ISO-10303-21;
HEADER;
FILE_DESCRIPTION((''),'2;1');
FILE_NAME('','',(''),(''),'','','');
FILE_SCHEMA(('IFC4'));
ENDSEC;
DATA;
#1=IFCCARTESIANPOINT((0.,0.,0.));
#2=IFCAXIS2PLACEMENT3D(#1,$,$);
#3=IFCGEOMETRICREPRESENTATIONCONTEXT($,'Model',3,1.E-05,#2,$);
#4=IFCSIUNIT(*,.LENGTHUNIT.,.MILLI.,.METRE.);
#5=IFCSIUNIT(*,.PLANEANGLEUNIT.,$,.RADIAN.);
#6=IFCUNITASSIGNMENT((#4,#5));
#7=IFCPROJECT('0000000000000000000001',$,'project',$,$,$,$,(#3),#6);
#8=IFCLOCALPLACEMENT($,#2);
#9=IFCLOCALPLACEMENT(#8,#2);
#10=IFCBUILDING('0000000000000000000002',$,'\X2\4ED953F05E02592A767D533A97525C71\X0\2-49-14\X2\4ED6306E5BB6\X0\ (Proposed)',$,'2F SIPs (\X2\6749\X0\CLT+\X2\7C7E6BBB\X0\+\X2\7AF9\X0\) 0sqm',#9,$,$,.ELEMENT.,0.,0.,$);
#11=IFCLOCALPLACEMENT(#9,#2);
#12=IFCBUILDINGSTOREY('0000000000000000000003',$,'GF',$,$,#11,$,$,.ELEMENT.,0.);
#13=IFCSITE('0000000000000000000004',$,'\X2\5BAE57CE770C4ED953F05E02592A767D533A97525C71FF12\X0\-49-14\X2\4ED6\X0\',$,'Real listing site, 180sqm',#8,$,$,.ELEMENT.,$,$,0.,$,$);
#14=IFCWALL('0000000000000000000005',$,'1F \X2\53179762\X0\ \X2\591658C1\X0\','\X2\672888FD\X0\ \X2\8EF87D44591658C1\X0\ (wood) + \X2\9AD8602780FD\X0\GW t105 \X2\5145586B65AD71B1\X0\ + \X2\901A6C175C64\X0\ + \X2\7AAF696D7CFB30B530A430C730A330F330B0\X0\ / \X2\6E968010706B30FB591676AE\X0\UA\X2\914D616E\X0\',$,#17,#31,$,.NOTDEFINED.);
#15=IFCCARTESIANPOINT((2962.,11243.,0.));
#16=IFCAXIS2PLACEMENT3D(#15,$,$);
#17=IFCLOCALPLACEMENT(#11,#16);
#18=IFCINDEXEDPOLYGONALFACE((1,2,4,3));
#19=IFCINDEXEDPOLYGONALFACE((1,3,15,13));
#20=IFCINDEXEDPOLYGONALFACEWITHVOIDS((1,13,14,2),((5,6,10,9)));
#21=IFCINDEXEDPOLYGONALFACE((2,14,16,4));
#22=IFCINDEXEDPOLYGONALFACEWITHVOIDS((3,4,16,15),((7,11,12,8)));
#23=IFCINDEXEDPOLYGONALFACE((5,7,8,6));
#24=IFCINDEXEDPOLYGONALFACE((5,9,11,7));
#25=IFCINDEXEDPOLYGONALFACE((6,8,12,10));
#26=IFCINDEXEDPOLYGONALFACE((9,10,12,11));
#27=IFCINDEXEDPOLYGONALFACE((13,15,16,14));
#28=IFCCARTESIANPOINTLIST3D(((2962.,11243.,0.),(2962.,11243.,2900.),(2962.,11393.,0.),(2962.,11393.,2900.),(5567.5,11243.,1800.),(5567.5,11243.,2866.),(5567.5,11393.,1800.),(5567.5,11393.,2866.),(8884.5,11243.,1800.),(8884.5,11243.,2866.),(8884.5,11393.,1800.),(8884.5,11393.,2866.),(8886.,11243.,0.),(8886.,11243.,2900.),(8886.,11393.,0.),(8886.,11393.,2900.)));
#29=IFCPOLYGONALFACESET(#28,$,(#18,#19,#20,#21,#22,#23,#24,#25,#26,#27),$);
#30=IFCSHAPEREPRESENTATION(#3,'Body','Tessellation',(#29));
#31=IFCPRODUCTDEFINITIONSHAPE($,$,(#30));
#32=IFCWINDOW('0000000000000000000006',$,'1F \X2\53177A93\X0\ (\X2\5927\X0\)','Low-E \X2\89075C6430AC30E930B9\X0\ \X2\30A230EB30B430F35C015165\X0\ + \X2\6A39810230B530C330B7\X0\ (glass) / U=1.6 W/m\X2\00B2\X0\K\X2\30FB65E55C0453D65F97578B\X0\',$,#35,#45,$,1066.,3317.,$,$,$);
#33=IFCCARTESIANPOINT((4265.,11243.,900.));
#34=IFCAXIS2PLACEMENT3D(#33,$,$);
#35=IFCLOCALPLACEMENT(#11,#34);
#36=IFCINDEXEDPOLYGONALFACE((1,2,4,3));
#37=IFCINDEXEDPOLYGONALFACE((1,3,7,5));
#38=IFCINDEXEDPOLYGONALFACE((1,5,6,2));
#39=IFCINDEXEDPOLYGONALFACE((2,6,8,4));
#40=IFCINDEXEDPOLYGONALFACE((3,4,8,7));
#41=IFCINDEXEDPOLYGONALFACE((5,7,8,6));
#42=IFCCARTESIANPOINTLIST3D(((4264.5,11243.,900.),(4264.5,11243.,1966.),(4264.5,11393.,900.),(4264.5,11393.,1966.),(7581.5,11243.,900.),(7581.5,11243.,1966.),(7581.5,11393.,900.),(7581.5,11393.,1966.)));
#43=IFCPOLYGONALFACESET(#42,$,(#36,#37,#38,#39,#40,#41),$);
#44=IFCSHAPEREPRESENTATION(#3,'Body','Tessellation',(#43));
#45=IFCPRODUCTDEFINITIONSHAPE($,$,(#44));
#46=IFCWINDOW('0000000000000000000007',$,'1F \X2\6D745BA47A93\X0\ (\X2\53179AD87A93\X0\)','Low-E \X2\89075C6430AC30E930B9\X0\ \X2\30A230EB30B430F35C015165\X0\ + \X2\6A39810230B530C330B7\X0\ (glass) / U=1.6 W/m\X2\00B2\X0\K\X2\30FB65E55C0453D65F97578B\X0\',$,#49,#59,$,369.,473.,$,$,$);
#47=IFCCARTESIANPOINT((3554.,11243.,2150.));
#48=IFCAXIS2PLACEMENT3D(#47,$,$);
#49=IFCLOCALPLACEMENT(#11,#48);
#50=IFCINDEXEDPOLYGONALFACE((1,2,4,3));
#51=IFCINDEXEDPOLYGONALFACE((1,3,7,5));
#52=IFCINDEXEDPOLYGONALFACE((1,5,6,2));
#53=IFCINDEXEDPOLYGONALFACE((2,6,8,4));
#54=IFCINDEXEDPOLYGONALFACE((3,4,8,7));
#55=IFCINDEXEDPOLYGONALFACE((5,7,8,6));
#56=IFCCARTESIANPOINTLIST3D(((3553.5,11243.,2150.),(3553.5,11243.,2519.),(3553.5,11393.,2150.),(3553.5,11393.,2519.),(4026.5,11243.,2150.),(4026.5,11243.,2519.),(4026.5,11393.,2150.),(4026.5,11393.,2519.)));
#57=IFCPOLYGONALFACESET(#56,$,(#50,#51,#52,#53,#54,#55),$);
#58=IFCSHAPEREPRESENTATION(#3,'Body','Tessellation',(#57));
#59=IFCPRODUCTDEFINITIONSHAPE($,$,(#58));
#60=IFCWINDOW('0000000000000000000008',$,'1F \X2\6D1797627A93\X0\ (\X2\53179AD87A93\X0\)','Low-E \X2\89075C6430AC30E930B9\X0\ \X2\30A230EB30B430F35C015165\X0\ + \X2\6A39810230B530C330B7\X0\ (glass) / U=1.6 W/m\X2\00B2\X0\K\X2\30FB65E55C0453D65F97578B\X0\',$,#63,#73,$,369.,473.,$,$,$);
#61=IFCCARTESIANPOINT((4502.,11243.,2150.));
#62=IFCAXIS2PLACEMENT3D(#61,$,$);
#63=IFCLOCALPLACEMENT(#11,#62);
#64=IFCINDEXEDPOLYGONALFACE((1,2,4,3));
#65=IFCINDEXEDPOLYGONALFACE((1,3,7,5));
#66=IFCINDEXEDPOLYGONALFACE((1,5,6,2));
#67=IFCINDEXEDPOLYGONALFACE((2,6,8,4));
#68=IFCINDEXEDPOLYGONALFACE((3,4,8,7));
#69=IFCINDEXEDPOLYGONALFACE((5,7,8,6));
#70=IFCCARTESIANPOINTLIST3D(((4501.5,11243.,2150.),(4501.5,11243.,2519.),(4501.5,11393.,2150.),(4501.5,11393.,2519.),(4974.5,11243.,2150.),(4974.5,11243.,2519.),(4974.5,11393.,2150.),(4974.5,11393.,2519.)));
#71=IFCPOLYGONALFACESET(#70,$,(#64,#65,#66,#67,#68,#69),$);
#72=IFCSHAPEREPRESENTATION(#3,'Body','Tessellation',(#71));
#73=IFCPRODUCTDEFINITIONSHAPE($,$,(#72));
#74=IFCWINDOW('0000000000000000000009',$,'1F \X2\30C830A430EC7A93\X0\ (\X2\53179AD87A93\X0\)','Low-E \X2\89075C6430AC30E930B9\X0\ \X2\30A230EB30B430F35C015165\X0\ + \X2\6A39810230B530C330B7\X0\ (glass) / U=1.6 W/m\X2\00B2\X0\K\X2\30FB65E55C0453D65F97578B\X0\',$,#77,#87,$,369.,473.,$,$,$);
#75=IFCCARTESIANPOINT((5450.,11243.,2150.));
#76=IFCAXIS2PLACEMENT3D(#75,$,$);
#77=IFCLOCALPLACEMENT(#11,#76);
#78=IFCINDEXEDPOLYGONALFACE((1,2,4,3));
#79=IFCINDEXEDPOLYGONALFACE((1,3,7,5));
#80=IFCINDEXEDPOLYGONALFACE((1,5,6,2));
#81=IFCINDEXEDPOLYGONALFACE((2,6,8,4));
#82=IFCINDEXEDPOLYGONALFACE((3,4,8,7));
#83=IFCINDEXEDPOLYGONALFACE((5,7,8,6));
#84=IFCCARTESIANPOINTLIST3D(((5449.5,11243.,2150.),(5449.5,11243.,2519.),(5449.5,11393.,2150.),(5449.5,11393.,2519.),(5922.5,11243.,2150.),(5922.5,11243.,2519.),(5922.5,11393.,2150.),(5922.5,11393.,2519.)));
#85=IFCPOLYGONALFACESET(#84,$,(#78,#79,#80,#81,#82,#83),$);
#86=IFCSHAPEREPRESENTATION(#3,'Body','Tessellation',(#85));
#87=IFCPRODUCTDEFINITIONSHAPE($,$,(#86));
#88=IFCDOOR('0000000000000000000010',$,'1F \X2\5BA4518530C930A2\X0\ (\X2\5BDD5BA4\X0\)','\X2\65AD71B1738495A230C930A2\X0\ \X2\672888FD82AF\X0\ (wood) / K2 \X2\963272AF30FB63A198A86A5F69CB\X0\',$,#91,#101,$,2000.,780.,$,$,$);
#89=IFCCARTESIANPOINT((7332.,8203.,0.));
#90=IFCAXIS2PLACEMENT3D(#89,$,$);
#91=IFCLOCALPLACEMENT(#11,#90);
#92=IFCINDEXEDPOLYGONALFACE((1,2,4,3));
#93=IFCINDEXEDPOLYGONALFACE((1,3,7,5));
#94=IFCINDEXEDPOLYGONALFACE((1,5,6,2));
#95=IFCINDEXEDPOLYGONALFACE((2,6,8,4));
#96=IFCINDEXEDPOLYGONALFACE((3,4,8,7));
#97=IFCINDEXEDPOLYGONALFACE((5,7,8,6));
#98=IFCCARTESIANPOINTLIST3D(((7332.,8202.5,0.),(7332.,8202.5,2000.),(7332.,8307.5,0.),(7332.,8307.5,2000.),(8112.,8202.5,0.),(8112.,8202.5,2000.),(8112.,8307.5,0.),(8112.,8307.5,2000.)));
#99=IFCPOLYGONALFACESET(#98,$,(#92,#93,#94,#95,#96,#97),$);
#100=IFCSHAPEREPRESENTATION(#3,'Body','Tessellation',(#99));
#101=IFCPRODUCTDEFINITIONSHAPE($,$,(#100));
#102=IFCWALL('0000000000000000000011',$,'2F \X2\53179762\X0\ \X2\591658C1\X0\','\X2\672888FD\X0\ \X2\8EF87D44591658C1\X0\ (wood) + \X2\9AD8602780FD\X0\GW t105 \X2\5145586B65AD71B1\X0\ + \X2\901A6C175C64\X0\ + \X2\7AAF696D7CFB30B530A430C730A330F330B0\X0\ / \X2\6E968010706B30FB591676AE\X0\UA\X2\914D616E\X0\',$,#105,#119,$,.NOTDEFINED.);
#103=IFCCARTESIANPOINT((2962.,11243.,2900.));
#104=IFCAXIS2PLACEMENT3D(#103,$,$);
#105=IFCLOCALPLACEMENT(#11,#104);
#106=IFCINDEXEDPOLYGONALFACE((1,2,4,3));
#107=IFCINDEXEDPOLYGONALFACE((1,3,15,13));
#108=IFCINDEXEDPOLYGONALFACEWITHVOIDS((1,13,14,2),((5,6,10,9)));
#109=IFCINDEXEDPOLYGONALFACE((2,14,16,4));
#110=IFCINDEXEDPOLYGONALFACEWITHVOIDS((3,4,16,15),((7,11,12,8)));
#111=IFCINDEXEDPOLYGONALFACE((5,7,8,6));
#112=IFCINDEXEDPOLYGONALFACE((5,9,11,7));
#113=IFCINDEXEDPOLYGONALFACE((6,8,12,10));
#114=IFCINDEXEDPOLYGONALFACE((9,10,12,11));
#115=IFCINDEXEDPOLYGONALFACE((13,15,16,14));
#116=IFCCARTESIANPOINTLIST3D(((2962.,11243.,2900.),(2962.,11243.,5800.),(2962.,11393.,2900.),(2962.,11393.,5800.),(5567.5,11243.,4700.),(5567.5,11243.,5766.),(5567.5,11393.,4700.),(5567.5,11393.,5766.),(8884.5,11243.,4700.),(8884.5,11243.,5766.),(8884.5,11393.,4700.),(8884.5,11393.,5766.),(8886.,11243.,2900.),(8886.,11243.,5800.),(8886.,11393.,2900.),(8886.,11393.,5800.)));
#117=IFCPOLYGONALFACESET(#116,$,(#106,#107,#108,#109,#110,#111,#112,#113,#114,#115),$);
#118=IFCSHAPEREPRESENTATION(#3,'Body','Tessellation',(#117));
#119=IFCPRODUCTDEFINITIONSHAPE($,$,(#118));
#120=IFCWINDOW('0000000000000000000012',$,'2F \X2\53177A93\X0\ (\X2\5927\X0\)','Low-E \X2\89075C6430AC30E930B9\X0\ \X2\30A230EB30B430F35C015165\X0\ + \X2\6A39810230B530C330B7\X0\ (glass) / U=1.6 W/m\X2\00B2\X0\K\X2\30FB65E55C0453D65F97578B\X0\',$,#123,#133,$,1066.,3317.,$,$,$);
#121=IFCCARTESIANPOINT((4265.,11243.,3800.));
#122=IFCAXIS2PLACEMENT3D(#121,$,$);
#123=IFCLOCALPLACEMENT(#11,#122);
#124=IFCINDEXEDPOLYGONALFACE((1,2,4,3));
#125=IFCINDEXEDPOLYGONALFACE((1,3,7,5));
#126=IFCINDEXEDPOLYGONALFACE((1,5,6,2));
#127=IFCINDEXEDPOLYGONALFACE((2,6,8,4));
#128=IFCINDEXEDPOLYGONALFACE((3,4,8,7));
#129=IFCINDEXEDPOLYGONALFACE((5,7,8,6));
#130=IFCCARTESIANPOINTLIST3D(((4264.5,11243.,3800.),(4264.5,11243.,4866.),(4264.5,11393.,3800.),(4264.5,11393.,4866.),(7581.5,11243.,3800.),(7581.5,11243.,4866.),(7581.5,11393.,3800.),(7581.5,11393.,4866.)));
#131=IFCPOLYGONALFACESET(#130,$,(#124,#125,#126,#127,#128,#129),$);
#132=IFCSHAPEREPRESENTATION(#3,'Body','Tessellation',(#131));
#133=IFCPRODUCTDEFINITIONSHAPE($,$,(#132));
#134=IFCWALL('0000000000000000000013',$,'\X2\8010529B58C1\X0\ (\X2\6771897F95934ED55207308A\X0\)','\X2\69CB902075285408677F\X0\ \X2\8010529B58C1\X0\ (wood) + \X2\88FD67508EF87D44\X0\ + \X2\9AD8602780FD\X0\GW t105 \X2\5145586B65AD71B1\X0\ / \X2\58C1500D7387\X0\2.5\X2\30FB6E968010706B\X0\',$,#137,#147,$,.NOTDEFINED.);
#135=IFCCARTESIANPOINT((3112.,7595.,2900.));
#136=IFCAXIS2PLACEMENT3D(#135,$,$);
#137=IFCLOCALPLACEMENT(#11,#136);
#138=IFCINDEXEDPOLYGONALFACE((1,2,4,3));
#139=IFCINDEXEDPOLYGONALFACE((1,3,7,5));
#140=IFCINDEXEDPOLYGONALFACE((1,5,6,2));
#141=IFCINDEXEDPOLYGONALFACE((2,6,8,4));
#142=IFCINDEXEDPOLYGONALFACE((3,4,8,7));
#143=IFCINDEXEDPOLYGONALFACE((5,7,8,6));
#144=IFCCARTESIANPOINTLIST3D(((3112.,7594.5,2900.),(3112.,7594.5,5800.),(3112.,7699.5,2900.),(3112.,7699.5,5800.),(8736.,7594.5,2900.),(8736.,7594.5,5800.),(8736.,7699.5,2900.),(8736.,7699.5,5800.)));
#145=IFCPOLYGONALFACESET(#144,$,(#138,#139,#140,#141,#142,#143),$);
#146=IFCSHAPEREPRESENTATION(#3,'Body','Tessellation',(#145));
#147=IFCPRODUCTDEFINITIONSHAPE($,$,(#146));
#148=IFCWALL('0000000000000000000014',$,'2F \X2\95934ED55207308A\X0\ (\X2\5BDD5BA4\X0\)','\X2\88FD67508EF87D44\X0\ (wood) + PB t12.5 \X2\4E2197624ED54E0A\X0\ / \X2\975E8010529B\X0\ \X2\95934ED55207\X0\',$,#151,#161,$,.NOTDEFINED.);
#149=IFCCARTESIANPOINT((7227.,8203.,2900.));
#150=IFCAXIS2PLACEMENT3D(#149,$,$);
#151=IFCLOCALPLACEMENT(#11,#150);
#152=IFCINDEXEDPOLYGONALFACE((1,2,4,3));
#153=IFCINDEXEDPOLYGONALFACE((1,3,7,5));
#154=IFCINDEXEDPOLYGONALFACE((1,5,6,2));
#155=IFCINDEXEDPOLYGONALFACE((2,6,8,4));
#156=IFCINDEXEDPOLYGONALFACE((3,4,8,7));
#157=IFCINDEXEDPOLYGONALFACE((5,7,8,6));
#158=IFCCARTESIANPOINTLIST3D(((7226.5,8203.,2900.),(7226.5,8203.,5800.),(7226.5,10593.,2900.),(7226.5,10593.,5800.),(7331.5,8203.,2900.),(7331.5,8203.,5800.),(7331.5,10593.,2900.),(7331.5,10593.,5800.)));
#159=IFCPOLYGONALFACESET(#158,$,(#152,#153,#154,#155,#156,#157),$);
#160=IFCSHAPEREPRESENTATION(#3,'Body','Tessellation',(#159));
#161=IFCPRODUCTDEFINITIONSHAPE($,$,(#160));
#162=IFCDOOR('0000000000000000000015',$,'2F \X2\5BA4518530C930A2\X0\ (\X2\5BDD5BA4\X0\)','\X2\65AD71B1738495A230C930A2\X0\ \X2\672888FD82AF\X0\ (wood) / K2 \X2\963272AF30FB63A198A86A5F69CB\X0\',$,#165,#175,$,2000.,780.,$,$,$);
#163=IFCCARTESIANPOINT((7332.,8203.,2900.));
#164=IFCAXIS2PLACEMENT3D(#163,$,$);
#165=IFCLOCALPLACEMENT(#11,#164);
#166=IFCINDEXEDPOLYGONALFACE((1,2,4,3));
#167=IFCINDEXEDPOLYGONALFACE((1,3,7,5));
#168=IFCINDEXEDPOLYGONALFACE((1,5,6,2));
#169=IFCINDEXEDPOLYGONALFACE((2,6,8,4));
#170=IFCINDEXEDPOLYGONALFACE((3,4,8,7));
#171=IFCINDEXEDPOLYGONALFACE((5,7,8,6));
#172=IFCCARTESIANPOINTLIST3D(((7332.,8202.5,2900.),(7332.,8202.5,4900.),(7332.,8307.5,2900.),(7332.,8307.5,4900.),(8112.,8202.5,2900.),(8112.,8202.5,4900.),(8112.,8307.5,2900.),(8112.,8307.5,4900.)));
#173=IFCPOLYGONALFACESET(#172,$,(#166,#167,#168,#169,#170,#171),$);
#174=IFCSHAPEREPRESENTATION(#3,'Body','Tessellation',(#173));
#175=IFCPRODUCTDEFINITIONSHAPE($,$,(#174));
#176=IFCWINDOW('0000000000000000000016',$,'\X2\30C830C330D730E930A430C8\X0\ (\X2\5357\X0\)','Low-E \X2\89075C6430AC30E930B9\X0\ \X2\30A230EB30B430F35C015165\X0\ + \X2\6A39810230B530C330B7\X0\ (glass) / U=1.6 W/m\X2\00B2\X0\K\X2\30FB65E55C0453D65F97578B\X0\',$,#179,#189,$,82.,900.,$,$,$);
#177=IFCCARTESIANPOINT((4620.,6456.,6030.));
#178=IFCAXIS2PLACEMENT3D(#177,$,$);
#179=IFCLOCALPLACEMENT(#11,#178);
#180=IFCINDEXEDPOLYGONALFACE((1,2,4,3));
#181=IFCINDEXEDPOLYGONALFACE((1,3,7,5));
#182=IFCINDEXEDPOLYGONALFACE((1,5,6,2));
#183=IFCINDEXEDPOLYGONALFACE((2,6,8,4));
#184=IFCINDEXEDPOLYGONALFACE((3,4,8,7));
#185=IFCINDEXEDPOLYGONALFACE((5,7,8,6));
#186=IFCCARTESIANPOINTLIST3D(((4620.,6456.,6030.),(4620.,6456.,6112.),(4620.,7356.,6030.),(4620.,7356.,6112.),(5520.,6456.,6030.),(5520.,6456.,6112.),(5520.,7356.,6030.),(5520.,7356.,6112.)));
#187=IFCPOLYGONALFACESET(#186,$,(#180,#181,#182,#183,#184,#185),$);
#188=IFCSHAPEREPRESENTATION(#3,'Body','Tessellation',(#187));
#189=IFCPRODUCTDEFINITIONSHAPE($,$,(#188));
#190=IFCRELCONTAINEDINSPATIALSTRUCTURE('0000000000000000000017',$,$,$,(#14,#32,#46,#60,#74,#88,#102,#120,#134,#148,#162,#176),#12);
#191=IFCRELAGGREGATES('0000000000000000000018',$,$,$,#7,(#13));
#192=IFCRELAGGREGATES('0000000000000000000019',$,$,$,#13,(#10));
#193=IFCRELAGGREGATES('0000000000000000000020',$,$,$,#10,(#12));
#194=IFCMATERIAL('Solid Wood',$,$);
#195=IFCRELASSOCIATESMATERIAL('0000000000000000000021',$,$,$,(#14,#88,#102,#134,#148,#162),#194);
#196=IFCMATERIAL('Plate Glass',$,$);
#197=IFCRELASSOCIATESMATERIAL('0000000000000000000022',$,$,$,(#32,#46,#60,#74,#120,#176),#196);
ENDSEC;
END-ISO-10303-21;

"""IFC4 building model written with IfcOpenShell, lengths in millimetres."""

from ifc_helpers import new_model, si_unit, frame, frame_2d, origin, place, context, project, spatial, rectangle, extrude, material, element, fill, save


model = new_model("IFC4")

# Units and contexts
model_context = context("Model", 3, precision=1e-05, world=origin())
ifc_project = project(units=[si_unit("LENGTHUNIT", "METRE", prefix="MILLI"), si_unit("PLANEANGLEUNIT", "RADIAN")], contexts=[model_context])

# Site, building, storey
site_placement = place(None, origin())
site = spatial("IfcSite", under=ifc_project, at=site_placement, Name="宮城県仙台市太白区青山２-49-14他", ObjectType="Real listing site, 180sqm", CompositionType="ELEMENT", RefElevation=0.0)
building_placement = place(site_placement, origin())
building = spatial("IfcBuilding", under=site, at=building_placement, Name="仙台市太白区青山2-49-14他の家 (Proposed)", ObjectType="2F SIPs (杉CLT+籾殻+竹) 0sqm", CompositionType="ELEMENT", ElevationOfRefHeight=0.0, ElevationOfTerrain=0.0)
storey_placement = place(building_placement, origin())
storey = spatial("IfcBuildingStorey", under=building, at=storey_placement, Name="GF", CompositionType="ELEMENT", Elevation=0.0)

# Wall, openings, windows
ifc_material_1 = material(Name="Solid Wood")
wall_1_placement = place(storey_placement, frame((2962.0, 11243.0, 0.0)))
wall_1 = element("IfcWall", 1, at=wall_1_placement, inside=storey, material=ifc_material_1, Name="1F 北面 外壁", Description="木製 軸組外壁 (wood) + 高性能GW t105 充填断熱 + 通気層 + 窯業系サイディング / 準耐火・外皮UA配慮", PredefinedType="NOTDEFINED", context=model_context, shape_type="SweptSolid", body=[
    extrude(rectangle(XDim=5924.0, YDim=150.0, at=frame_2d((2962.0, 75.0))), frame((2962.0, 11243.0, 0.0)), (0.0, 0.0, 1.0), 2900.0),
])
opening_1_placement = place(storey_placement, frame((4265.0, 11243.0, 900.0)))
opening_1 = element("IfcOpeningElement", 2, at=opening_1_placement, cuts=wall_1, PredefinedType="NOTDEFINED", context=model_context, shape_type="SweptSolid", body=[
    extrude(rectangle(XDim=3317.0, YDim=150.0, at=frame_2d((1658.0, 75.0))), frame((4265.0, 11243.0, 900.0)), (0.0, 0.0, 1.0), 1066.0),
])
opening_2_placement = place(storey_placement, frame((3554.0, 11243.0, 2150.0)))
opening_2 = element("IfcOpeningElement", 3, at=opening_2_placement, cuts=wall_1, PredefinedType="NOTDEFINED", context=model_context, shape_type="SweptSolid", body=[
    extrude(rectangle(XDim=473.0, YDim=150.0, at=frame_2d((236.0, 75.0))), frame((3554.0, 11243.0, 2150.0)), (0.0, 0.0, 1.0), 369.0),
])
opening_3_placement = place(storey_placement, frame((4502.0, 11243.0, 2150.0)))
opening_3 = element("IfcOpeningElement", 4, at=opening_3_placement, cuts=wall_1, PredefinedType="NOTDEFINED", context=model_context, shape_type="SweptSolid", body=[
    extrude(rectangle(XDim=473.0, YDim=150.0, at=frame_2d((236.0, 75.0))), frame((4502.0, 11243.0, 2150.0)), (0.0, 0.0, 1.0), 369.0),
])
opening_4_placement = place(storey_placement, frame((5450.0, 11243.0, 2150.0)))
opening_4 = element("IfcOpeningElement", 5, at=opening_4_placement, cuts=wall_1, PredefinedType="NOTDEFINED", context=model_context, shape_type="SweptSolid", body=[
    extrude(rectangle(XDim=473.0, YDim=150.0, at=frame_2d((236.0, 75.0))), frame((5450.0, 11243.0, 2150.0)), (0.0, 0.0, 1.0), 369.0),
])
ifc_material_2 = material(Name="Plate Glass")
window_1_placement = place(storey_placement, frame((4265.0, 11243.0, 900.0)))
window_1 = element("IfcWindow", 6, at=window_1_placement, inside=storey, material=ifc_material_2, Name="1F 北窓 (大)", Description="Low-E 複層ガラス アルゴン封入 + 樹脂サッシ (glass) / U=1.6 W/m²K・日射取得型", OverallHeight=1066.0, OverallWidth=3317.0, context=model_context, shape_type="SweptSolid", body=[
    extrude(rectangle(XDim=3317.0, YDim=150.0, at=frame_2d((1658.0, 75.0))), frame((4265.0, 11243.0, 900.0)), (0.0, 0.0, 1.0), 1066.0),
])
fill(opening_1, window_1)
window_2_placement = place(storey_placement, frame((3554.0, 11243.0, 2150.0)))
window_2 = element("IfcWindow", 7, at=window_2_placement, inside=storey, material=ifc_material_2, Name="1F 浴室窓 (北高窓)", Description="Low-E 複層ガラス アルゴン封入 + 樹脂サッシ (glass) / U=1.6 W/m²K・日射取得型", OverallHeight=369.0, OverallWidth=473.0, context=model_context, shape_type="SweptSolid", body=[
    extrude(rectangle(XDim=473.0, YDim=150.0, at=frame_2d((236.0, 75.0))), frame((3554.0, 11243.0, 2150.0)), (0.0, 0.0, 1.0), 369.0),
])
fill(opening_2, window_2)
window_3_placement = place(storey_placement, frame((4502.0, 11243.0, 2150.0)))
window_3 = element("IfcWindow", 8, at=window_3_placement, inside=storey, material=ifc_material_2, Name="1F 洗面窓 (北高窓)", Description="Low-E 複層ガラス アルゴン封入 + 樹脂サッシ (glass) / U=1.6 W/m²K・日射取得型", OverallHeight=369.0, OverallWidth=473.0, context=model_context, shape_type="SweptSolid", body=[
    extrude(rectangle(XDim=473.0, YDim=150.0, at=frame_2d((236.0, 75.0))), frame((4502.0, 11243.0, 2150.0)), (0.0, 0.0, 1.0), 369.0),
])
fill(opening_3, window_3)
window_4_placement = place(storey_placement, frame((5450.0, 11243.0, 2150.0)))
window_4 = element("IfcWindow", 9, at=window_4_placement, inside=storey, material=ifc_material_2, Name="1F トイレ窓 (北高窓)", Description="Low-E 複層ガラス アルゴン封入 + 樹脂サッシ (glass) / U=1.6 W/m²K・日射取得型", OverallHeight=369.0, OverallWidth=473.0, context=model_context, shape_type="SweptSolid", body=[
    extrude(rectangle(XDim=473.0, YDim=150.0, at=frame_2d((236.0, 75.0))), frame((5450.0, 11243.0, 2150.0)), (0.0, 0.0, 1.0), 369.0),
])
fill(opening_4, window_4)

# Door
door_1_placement = place(storey_placement, frame((7332.0, 8203.0, 0.0)))
element("IfcDoor", 10, at=door_1_placement, inside=storey, material=ifc_material_1, Name="1F 室内ドア (寝室)", Description="断熱玄関ドア 木製芯 (wood) / K2 防犯・採風機構", OverallHeight=2000.0, OverallWidth=780.0, context=model_context, shape_type="SweptSolid", body=[
    extrude(rectangle(XDim=780.0, YDim=105.0, at=frame_2d((390.0, 52.0))), frame((7332.0, 8203.0, 0.0)), (0.0, 0.0, 1.0), 2000.0),
])

# Wall, opening, window
wall_2_placement = place(storey_placement, frame((2962.0, 11243.0, 2900.0)))
wall_2 = element("IfcWall", 11, at=wall_2_placement, inside=storey, material=ifc_material_1, Name="2F 北面 外壁", Description="木製 軸組外壁 (wood) + 高性能GW t105 充填断熱 + 通気層 + 窯業系サイディング / 準耐火・外皮UA配慮", PredefinedType="NOTDEFINED", context=model_context, shape_type="SweptSolid", body=[
    extrude(rectangle(XDim=5924.0, YDim=150.0, at=frame_2d((2962.0, 75.0))), frame((2962.0, 11243.0, 2900.0)), (0.0, 0.0, 1.0), 2900.0),
])
opening_5_placement = place(storey_placement, frame((4265.0, 11243.0, 3800.0)))
opening_5 = element("IfcOpeningElement", 12, at=opening_5_placement, cuts=wall_2, PredefinedType="NOTDEFINED", context=model_context, shape_type="SweptSolid", body=[
    extrude(rectangle(XDim=3317.0, YDim=150.0, at=frame_2d((1658.0, 75.0))), frame((4265.0, 11243.0, 3800.0)), (0.0, 0.0, 1.0), 1066.0),
])
window_5_placement = place(storey_placement, frame((4265.0, 11243.0, 3800.0)))
window_5 = element("IfcWindow", 13, at=window_5_placement, inside=storey, material=ifc_material_2, Name="2F 北窓 (大)", Description="Low-E 複層ガラス アルゴン封入 + 樹脂サッシ (glass) / U=1.6 W/m²K・日射取得型", OverallHeight=1066.0, OverallWidth=3317.0, context=model_context, shape_type="SweptSolid", body=[
    extrude(rectangle(XDim=3317.0, YDim=150.0, at=frame_2d((1658.0, 75.0))), frame((4265.0, 11243.0, 3800.0)), (0.0, 0.0, 1.0), 1066.0),
])
fill(opening_5, window_5)

# Walls
wall_3_placement = place(storey_placement, frame((3112.0, 7595.0, 2900.0)))
element("IfcWall", 14, at=wall_3_placement, inside=storey, material=ifc_material_1, Name="耐力壁 (東西間仕切り)", Description="構造用合板 耐力壁 (wood) + 製材軸組 + 高性能GW t105 充填断熱 / 壁倍率2.5・準耐火", PredefinedType="NOTDEFINED", context=model_context, shape_type="SweptSolid", body=[
    extrude(rectangle(XDim=5624.0, YDim=105.0, at=frame_2d((2812.0, 52.0))), frame((3112.0, 7595.0, 2900.0)), (0.0, 0.0, 1.0), 2900.0),
])
wall_4_placement = place(storey_placement, frame((7227.0, 8203.0, 2900.0)))
element("IfcWall", 15, at=wall_4_placement, inside=storey, material=ifc_material_1, Name="2F 間仕切り (寝室)", Description="製材軸組 (wood) + PB t12.5 両面仕上 / 非耐力 間仕切", PredefinedType="NOTDEFINED", context=model_context, shape_type="SweptSolid", body=[
    extrude(rectangle(XDim=105.0, YDim=2390.0, at=frame_2d((52.0, 1195.0))), frame((7227.0, 8203.0, 2900.0)), (0.0, 0.0, 1.0), 2900.0),
])

# Door
door_2_placement = place(storey_placement, frame((7332.0, 8203.0, 2900.0)))
element("IfcDoor", 16, at=door_2_placement, inside=storey, material=ifc_material_1, Name="2F 室内ドア (寝室)", Description="断熱玄関ドア 木製芯 (wood) / K2 防犯・採風機構", OverallHeight=2000.0, OverallWidth=780.0, context=model_context, shape_type="SweptSolid", body=[
    extrude(rectangle(XDim=780.0, YDim=105.0, at=frame_2d((390.0, 52.0))), frame((7332.0, 8203.0, 2900.0)), (0.0, 0.0, 1.0), 2000.0),
])

# Window
window_6_placement = place(storey_placement, frame((4620.0, 6456.0, 6030.0)))
element("IfcWindow", 17, at=window_6_placement, inside=storey, material=ifc_material_2, Name="トップライト (南)", Description="Low-E 複層ガラス アルゴン封入 + 樹脂サッシ (glass) / U=1.6 W/m²K・日射取得型", OverallHeight=82.0, OverallWidth=900.0, context=model_context, shape_type="SweptSolid", body=[
    extrude(rectangle(XDim=900.0, YDim=900.0, at=frame_2d((450.0, 450.0))), frame((4620.0, 6456.0, 6030.0)), (0.0, 0.0, 1.0), 82.0),
])

save(model, "model.ifc")
